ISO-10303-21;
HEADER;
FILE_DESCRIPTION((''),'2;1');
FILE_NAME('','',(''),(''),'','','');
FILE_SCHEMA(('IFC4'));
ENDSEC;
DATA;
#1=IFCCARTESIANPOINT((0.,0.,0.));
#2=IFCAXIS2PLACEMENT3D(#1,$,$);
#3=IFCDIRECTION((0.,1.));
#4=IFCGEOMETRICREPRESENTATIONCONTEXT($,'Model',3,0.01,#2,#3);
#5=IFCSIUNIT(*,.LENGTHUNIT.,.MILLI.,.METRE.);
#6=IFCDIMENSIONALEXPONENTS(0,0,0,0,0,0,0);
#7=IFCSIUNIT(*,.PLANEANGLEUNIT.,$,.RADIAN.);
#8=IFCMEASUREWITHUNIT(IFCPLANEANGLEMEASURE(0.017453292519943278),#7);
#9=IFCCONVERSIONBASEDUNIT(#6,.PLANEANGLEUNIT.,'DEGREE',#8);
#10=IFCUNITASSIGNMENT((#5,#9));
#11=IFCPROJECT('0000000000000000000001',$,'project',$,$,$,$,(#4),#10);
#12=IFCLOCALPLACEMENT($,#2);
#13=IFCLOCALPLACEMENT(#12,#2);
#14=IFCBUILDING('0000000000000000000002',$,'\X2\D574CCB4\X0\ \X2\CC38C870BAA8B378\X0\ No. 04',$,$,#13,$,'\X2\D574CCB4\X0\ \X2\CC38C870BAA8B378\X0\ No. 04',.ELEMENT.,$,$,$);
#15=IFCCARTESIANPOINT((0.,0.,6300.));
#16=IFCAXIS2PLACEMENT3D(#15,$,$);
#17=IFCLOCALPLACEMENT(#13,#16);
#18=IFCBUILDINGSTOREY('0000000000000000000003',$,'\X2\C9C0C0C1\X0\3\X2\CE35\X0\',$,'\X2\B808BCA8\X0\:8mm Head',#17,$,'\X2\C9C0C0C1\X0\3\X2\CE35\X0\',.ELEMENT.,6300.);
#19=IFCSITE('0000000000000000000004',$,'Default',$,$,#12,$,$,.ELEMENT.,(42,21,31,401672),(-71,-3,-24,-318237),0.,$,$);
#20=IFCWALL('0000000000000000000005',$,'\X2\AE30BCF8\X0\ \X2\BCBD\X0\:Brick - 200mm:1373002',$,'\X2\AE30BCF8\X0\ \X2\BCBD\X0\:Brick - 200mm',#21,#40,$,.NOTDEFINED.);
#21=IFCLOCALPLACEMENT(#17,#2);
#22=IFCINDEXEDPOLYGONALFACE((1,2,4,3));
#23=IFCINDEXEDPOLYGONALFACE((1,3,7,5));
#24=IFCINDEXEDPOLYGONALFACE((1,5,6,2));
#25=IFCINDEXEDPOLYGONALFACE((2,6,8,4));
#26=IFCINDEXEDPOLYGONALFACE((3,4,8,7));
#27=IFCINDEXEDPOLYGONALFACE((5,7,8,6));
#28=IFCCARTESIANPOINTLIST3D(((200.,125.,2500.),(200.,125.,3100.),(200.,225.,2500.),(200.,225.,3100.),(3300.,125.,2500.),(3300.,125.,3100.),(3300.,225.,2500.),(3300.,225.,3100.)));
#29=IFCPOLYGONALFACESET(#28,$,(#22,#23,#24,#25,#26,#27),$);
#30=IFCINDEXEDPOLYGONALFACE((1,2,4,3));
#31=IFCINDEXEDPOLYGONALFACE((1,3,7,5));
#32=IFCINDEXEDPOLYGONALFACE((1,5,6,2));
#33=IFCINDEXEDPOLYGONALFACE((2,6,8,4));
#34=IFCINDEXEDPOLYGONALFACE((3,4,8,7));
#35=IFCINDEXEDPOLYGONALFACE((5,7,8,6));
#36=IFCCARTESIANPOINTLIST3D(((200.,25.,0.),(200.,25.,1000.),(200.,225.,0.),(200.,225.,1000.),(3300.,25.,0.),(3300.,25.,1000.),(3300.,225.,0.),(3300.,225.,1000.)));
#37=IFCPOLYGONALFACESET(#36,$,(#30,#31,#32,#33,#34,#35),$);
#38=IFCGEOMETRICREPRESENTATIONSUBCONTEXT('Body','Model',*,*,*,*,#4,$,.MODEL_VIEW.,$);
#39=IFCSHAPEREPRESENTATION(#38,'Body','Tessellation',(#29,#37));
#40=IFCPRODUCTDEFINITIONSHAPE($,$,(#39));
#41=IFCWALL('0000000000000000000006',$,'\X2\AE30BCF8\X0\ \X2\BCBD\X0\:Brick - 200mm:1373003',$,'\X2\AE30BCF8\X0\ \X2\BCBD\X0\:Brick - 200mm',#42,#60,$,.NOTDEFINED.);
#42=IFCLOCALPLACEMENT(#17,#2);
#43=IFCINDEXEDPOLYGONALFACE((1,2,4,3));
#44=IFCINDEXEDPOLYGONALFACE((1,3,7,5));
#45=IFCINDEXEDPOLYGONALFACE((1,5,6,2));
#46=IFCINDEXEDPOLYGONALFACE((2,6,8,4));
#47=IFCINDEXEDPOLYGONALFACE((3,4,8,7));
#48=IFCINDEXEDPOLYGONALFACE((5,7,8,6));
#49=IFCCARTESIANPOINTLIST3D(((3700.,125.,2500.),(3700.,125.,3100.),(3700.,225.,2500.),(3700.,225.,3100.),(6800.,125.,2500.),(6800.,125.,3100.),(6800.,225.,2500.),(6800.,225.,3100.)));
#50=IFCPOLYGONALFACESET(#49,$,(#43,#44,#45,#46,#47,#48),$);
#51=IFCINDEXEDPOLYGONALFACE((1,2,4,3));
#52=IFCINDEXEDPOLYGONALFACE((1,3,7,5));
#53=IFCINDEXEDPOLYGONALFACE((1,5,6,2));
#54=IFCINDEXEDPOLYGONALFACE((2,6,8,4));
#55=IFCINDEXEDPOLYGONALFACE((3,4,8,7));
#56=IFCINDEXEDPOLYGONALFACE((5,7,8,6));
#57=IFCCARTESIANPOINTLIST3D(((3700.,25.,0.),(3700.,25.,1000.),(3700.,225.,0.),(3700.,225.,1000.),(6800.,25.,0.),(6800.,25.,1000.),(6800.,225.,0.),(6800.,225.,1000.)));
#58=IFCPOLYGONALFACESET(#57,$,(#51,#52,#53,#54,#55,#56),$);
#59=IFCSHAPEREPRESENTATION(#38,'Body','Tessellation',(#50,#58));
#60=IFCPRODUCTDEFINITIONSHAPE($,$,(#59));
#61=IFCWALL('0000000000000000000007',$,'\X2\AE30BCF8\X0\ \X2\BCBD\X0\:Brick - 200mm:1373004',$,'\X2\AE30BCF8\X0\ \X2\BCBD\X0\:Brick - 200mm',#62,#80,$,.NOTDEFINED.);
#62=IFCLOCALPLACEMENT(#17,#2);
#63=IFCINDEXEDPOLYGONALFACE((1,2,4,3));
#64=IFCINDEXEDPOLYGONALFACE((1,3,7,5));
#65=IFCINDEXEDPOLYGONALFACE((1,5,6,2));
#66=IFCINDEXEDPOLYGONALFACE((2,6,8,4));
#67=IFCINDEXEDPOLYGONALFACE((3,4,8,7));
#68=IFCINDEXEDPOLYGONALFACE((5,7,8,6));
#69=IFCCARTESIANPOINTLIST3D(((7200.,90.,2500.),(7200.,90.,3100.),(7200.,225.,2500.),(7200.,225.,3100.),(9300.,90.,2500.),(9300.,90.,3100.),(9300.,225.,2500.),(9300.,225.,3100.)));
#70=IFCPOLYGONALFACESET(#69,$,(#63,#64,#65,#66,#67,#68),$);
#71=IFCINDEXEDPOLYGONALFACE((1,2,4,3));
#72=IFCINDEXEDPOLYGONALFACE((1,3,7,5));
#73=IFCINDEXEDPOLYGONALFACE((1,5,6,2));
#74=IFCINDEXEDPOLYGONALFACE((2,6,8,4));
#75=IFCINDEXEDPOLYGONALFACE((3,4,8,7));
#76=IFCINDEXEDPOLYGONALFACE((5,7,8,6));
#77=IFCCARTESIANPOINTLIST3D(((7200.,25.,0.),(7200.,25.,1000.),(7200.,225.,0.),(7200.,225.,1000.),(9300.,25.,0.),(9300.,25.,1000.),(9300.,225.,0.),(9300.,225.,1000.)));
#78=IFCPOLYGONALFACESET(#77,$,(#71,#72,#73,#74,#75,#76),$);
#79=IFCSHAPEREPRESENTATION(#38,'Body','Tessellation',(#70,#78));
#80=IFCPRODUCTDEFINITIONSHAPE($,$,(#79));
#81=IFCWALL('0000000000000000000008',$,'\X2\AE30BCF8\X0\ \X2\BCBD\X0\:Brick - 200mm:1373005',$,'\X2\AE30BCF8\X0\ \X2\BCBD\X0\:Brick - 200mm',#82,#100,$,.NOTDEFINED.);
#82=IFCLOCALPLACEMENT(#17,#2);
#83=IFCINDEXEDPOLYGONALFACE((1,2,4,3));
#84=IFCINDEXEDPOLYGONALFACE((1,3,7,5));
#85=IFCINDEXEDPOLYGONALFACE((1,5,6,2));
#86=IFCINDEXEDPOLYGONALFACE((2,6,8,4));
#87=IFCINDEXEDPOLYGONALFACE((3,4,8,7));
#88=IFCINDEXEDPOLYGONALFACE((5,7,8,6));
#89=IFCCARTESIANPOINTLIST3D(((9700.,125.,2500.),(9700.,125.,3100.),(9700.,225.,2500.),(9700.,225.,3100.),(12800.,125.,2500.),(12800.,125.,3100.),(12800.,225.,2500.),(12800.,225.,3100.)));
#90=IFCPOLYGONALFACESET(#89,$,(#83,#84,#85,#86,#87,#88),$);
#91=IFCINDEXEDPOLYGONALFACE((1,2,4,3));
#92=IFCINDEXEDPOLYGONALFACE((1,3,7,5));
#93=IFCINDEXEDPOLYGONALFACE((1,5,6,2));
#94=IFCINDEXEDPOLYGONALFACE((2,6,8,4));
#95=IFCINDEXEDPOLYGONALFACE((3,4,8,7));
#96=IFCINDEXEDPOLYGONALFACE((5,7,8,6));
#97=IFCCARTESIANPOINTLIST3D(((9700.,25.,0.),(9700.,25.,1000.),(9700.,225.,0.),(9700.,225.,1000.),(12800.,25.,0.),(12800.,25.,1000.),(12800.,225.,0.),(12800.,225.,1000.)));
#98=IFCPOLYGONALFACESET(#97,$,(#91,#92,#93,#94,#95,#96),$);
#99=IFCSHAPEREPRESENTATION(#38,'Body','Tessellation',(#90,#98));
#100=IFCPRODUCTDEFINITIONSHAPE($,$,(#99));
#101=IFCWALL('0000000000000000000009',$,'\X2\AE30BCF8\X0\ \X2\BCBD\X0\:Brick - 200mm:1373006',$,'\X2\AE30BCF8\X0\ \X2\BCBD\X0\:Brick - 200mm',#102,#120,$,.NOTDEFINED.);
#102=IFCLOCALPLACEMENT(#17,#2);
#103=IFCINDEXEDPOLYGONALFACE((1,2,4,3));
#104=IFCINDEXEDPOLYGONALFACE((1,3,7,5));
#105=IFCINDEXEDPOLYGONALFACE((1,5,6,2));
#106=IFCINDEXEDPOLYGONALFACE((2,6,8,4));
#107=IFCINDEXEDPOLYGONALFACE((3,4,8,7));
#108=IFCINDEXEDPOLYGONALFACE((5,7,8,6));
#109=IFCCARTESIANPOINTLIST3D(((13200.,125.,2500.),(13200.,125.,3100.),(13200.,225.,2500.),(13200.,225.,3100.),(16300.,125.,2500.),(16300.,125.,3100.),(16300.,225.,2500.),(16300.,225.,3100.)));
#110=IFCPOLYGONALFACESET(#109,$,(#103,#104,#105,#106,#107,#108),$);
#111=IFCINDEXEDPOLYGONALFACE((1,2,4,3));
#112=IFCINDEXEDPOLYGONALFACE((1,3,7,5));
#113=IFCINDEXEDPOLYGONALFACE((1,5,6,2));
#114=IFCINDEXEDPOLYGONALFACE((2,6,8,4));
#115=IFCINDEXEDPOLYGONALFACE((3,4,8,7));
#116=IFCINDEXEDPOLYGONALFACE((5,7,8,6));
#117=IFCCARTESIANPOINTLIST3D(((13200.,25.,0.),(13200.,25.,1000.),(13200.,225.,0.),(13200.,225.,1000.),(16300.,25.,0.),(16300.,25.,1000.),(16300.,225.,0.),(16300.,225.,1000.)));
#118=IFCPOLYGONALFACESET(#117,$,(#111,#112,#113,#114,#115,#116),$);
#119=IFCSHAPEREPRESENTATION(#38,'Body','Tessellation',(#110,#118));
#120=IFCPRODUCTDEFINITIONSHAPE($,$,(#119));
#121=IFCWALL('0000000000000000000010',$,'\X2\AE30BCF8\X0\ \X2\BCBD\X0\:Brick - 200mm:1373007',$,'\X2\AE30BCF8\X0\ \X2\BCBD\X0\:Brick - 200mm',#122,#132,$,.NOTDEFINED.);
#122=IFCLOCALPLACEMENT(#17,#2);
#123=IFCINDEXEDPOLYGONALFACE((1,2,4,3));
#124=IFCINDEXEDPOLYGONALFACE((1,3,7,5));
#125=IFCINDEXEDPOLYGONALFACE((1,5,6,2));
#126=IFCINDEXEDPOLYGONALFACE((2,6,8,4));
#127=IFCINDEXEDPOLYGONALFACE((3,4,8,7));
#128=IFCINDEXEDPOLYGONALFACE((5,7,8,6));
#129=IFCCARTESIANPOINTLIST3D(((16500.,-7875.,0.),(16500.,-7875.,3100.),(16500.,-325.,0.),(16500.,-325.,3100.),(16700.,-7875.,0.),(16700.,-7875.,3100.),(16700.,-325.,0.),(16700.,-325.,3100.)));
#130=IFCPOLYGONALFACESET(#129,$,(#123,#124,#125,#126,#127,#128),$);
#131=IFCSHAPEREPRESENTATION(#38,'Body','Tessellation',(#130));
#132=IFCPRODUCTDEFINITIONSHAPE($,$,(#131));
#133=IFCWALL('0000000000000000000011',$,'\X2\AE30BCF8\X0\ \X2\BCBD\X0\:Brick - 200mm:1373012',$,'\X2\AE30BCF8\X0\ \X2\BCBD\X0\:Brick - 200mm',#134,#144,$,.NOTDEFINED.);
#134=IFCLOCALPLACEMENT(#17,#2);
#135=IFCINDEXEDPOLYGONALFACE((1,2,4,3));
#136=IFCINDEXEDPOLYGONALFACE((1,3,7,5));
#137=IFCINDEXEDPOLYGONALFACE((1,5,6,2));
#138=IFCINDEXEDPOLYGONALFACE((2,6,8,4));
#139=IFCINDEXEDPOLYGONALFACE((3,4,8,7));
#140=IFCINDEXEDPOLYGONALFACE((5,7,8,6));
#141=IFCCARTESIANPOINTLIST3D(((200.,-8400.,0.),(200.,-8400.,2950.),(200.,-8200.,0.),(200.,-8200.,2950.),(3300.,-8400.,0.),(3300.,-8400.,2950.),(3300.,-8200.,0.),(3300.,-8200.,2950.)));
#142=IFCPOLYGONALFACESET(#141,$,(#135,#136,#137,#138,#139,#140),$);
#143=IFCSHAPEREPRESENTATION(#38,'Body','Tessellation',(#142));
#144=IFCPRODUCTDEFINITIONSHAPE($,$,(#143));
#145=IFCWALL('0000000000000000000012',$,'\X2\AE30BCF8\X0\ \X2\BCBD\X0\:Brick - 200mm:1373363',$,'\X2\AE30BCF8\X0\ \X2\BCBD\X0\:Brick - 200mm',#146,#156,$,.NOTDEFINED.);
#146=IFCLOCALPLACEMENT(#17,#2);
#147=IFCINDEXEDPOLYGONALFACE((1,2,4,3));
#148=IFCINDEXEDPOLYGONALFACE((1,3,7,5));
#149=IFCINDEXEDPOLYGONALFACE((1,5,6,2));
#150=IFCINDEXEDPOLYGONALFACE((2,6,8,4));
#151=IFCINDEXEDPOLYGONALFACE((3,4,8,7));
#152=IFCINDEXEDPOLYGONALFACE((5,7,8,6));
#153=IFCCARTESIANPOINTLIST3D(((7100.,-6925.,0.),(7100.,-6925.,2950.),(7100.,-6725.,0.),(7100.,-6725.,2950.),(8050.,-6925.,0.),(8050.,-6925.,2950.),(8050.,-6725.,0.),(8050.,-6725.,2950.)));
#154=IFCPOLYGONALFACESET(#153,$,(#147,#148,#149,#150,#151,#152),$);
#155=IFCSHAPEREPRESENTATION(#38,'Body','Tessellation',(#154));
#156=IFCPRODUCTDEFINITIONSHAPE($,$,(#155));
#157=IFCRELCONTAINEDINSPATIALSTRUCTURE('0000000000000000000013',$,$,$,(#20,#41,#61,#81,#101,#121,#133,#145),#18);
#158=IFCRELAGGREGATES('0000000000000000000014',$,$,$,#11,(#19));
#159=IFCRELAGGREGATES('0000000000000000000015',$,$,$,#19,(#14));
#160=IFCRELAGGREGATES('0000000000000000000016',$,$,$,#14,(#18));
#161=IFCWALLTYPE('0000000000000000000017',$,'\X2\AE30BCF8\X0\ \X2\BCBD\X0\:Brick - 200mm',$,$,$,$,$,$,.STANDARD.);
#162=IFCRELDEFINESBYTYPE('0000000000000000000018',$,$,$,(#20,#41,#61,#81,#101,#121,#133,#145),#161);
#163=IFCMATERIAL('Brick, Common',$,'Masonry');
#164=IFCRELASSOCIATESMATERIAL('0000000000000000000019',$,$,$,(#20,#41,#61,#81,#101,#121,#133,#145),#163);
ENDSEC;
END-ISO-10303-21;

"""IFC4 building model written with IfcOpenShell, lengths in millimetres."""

from ifc_helpers import new_model, entity, si_unit, converted_unit, direction, frame, origin, place, context, subcontext, project, spatial, indexed_curve, outline, extrude, material, type_object, element, save


model = new_model("IFC4")

# Units and contexts
model_context = context("Model", 3, precision=0.01, world=origin(), true_north=direction((0.0, 1.0)))
body_context = subcontext(model_context, "Body", "Model", "MODEL_VIEW")
ifc_project = project(units=[si_unit("LENGTHUNIT", "METRE", prefix="MILLI"), converted_unit("PLANEANGLEUNIT", "DEGREE", entity("IfcPlaneAngleMeasure", 0.017453292519943278), si_unit("PLANEANGLEUNIT", "RADIAN"), dimensions=[0, 0, 0, 0, 0, 0, 0])], contexts=[model_context])

# Site, building, storey
site_placement = place(None, origin())
site = spatial("IfcSite", under=ifc_project, at=site_placement, Name="Default", CompositionType="ELEMENT", RefLatitude=(42, 21, 31, 401672), RefLongitude=(-71, -3, -24, -318237), RefElevation=0.0)
building_placement = place(site_placement, origin())
building = spatial("IfcBuilding", under=site, at=building_placement, Name="해체 참조모델 No. 04", LongName="해체 참조모델 No. 04", CompositionType="ELEMENT")
storey_placement = place(building_placement, frame((0.0, 0.0, 6300.0)))
storey = spatial("IfcBuildingStorey", under=building, at=storey_placement, Name="지상3층", ObjectType="레벨:8mm Head", LongName="지상3층", CompositionType="ELEMENT", Elevation=6300.0)

# Shared definitions
ifc_material_1 = material(Name="Brick, Common", Category="Masonry")
wall_type = type_object("IfcWallType", Name="기본 벽:Brick - 200mm", PredefinedType="STANDARD")

# Walls, openings
wall_1_placement = place(storey_placement, frame((200.0, 125.0, 0.0)))
wall_1 = element("IfcWall", 1, at=wall_1_placement, inside=storey, type_object=wall_type, material=ifc_material_1, Name="기본 벽:Brick - 200mm:1373002", ObjectType="기본 벽:Brick - 200mm", PredefinedType="NOTDEFINED", context=body_context, shape_type="SweptSolid", body=[
    extrude(outline(indexed_curve([(-50.0, -1550.0), (50.0, -1550.0), (50.0, 1550.0), (-50.0, 1550.0), (-50.0, -1550.0)], self_intersect=False)), frame((1550.0, 50.0, 2500.0), z_axis=(0.0, 0.0, 1.0), x_axis=(0.0, -1.0, 0.0)), (0.0, 0.0, 1.0), 600.0),
    extrude(outline(indexed_curve([(-100.0, -1550.0), (0.0, -1550.0), (100.0, -1550.0), (100.0, 1550.0), (0.0, 1550.0), (-100.0, 1550.0), (-100.0, -1550.0)], self_intersect=False)), frame((1550.0, 0.0, 0.0), z_axis=(0.0, 0.0, 1.0), x_axis=(0.0, 1.0, 0.0)), (0.0, 0.0, 1.0), 1000.0),
])
opening_1_placement = place(wall_1_placement, origin())
element("IfcOpeningElement", 2, at=opening_1_placement, cuts=wall_1, PredefinedType="OPENING", context=body_context, shape_type="SweptSolid", body=[
    extrude(outline(indexed_curve([(-750.0, -1550.0), (750.0, -1550.0), (750.0, 1550.0), (-750.0, 1550.0), (-750.0, -1550.0)], self_intersect=False)), frame((1550.0, -252.4, 1750.0), z_axis=(0.0, 1.0, 0.0), x_axis=(0.0, 0.0, 1.0)), (0.0, 0.0, 1.0), 504.8),
])
wall_2_placement = place(storey_placement, frame((3700.0, 125.0, 0.0)))
wall_2 = element("IfcWall", 3, at=wall_2_placement, inside=storey, type_object=wall_type, material=ifc_material_1, Name="기본 벽:Brick - 200mm:1373003", ObjectType="기본 벽:Brick - 200mm", PredefinedType="NOTDEFINED", context=body_context, shape_type="SweptSolid", body=[
    extrude(outline(indexed_curve([(-50.0, -1550.0), (50.0, -1550.0), (50.0, 1550.0), (-50.0, 1550.0), (-50.0, -1550.0)], self_intersect=False)), frame((1550.0, 50.0, 2500.0), z_axis=(0.0, 0.0, 1.0), x_axis=(0.0, -1.0, 0.0)), (0.0, 0.0, 1.0), 600.0),
    extrude(outline(indexed_curve([(-100.0, -1550.0), (0.0, -1550.0), (100.0, -1550.0), (100.0, 1550.0), (0.0, 1550.0), (-100.0, 1550.0), (-100.0, -1550.0)], self_intersect=False)), frame((1550.0, 0.0, 0.0), z_axis=(0.0, 0.0, 1.0), x_axis=(0.0, 1.0, 0.0)), (0.0, 0.0, 1.0), 1000.0),
])
opening_2_placement = place(wall_2_placement, origin())
element("IfcOpeningElement", 4, at=opening_2_placement, cuts=wall_2, PredefinedType="OPENING", context=body_context, shape_type="SweptSolid", body=[
    extrude(outline(indexed_curve([(-750.0, -1550.0), (750.0, -1550.0), (750.0, 1550.0), (-750.0, 1550.0), (-750.0, -1550.0)], self_intersect=False)), frame((1550.0, -252.4, 1750.0), z_axis=(0.0, 1.0, 0.0), x_axis=(0.0, 0.0, 1.0)), (0.0, 0.0, 1.0), 504.8),
])
wall_3_placement = place(storey_placement, frame((7200.0, 125.0, 0.0)))
wall_3 = element("IfcWall", 5, at=wall_3_placement, inside=storey, type_object=wall_type, material=ifc_material_1, Name="기본 벽:Brick - 200mm:1373004", ObjectType="기본 벽:Brick - 200mm", PredefinedType="NOTDEFINED", context=body_context, shape_type="SweptSolid", body=[
    extrude(outline(indexed_curve([(-67.5, -1050.0), (67.5, -1050.0), (67.5, 1050.0), (-67.5, 1050.0), (-67.5, -1050.0)], self_intersect=False)), frame((1050.0, 32.5, 2500.0), z_axis=(0.0, 0.0, 1.0), x_axis=(0.0, -1.0, 0.0)), (0.0, 0.0, 1.0), 600.0),
    extrude(outline(indexed_curve([(-88.3, -1050.0), (-23.3, -1050.0), (111.7, -1050.0), (111.7, 1050.0), (-23.3, 1050.0), (-88.3, 1050.0), (-88.3, -1050.0)], self_intersect=False)), frame((1050.0, -11.7, 0.0), z_axis=(0.0, 0.0, 1.0), x_axis=(0.0, 1.0, 0.0)), (0.0, 0.0, 1.0), 1000.0),
])
opening_3_placement = place(wall_3_placement, origin())
element("IfcOpeningElement", 6, at=opening_3_placement, cuts=wall_3, PredefinedType="OPENING", context=body_context, shape_type="SweptSolid", body=[
    extrude(outline(indexed_curve([(-750.0, -1050.0), (750.0, -1050.0), (750.0, 1050.0), (-750.0, 1050.0), (-750.0, -1050.0)], self_intersect=False)), frame((1050.0, -252.4, 1750.0), z_axis=(0.0, 1.0, 0.0), x_axis=(0.0, 0.0, 1.0)), (0.0, 0.0, 1.0), 504.8),
])
wall_4_placement = place(storey_placement, frame((9700.0, 125.0, 0.0)))
wall_4 = element("IfcWall", 7, at=wall_4_placement, inside=storey, type_object=wall_type, material=ifc_material_1, Name="기본 벽:Brick - 200mm:1373005", ObjectType="기본 벽:Brick - 200mm", PredefinedType="NOTDEFINED", context=body_context, shape_type="SweptSolid", body=[
    extrude(outline(indexed_curve([(-50.0, -1550.0), (50.0, -1550.0), (50.0, 1550.0), (-50.0, 1550.0), (-50.0, -1550.0)], self_intersect=False)), frame((1550.0, 50.0, 2500.0), z_axis=(0.0, 0.0, 1.0), x_axis=(0.0, -1.0, 0.0)), (0.0, 0.0, 1.0), 600.0),
    extrude(outline(indexed_curve([(-100.0, -1550.0), (0.0, -1550.0), (100.0, -1550.0), (100.0, 1550.0), (0.0, 1550.0), (-100.0, 1550.0), (-100.0, -1550.0)], self_intersect=False)), frame((1550.0, 0.0, 0.0), z_axis=(0.0, 0.0, 1.0), x_axis=(0.0, 1.0, 0.0)), (0.0, 0.0, 1.0), 1000.0),
])
opening_4_placement = place(wall_4_placement, origin())
element("IfcOpeningElement", 8, at=opening_4_placement, cuts=wall_4, PredefinedType="OPENING", context=body_context, shape_type="SweptSolid", body=[
    extrude(outline(indexed_curve([(-750.0, -1550.0), (750.0, -1550.0), (750.0, 1550.0), (-750.0, 1550.0), (-750.0, -1550.0)], self_intersect=False)), frame((1550.0, -252.4, 1750.0), z_axis=(0.0, 1.0, 0.0), x_axis=(0.0, 0.0, 1.0)), (0.0, 0.0, 1.0), 504.8),
])
wall_5_placement = place(storey_placement, frame((13200.0, 125.0, 0.0)))
wall_5 = element("IfcWall", 9, at=wall_5_placement, inside=storey, type_object=wall_type, material=ifc_material_1, Name="기본 벽:Brick - 200mm:1373006", ObjectType="기본 벽:Brick - 200mm", PredefinedType="NOTDEFINED", context=body_context, shape_type="SweptSolid", body=[
    extrude(outline(indexed_curve([(-50.0, -1550.0), (50.0, -1550.0), (50.0, 1550.0), (-50.0, 1550.0), (-50.0, -1550.0)], self_intersect=False)), frame((1550.0, 50.0, 2500.0), z_axis=(0.0, 0.0, 1.0), x_axis=(0.0, -1.0, 0.0)), (0.0, 0.0, 1.0), 600.0),
    extrude(outline(indexed_curve([(-100.0, -1550.0), (0.0, -1550.0), (100.0, -1550.0), (100.0, 1550.0), (0.0, 1550.0), (-100.0, 1550.0), (-100.0, -1550.0)], self_intersect=False)), frame((1550.0, 0.0, 0.0), z_axis=(0.0, 0.0, 1.0), x_axis=(0.0, 1.0, 0.0)), (0.0, 0.0, 1.0), 1000.0),
])
opening_5_placement = place(wall_5_placement, origin())
element("IfcOpeningElement", 10, at=opening_5_placement, cuts=wall_5, PredefinedType="OPENING", context=body_context, shape_type="SweptSolid", body=[
    extrude(outline(indexed_curve([(-750.0, -1550.0), (750.0, -1550.0), (750.0, 1550.0), (-750.0, 1550.0), (-750.0, -1550.0)], self_intersect=False)), frame((1550.0, -252.4, 1750.0), z_axis=(0.0, 1.0, 0.0), x_axis=(0.0, 0.0, 1.0)), (0.0, 0.0, 1.0), 504.8),
])

# Walls
wall_6_placement = place(storey_placement, frame((16600.0, -325.0, 0.0), z_axis=(0.0, 0.0, 1.0), x_axis=(0.0, -1.0, 0.0)))
element("IfcWall", 11, at=wall_6_placement, inside=storey, type_object=wall_type, material=ifc_material_1, Name="기본 벽:Brick - 200mm:1373007", ObjectType="기본 벽:Brick - 200mm", PredefinedType="NOTDEFINED", context=body_context, shape_type="SweptSolid", body=[
    extrude(outline(indexed_curve([(7550.0, 100.0), (0.0, 100.0), (0.0, -100.0), (7550.0, -100.0), (7550.0, 100.0)], self_intersect=False)), origin(), (0.0, 0.0, 1.0), 3100.0),
])
wall_7_placement = place(storey_placement, frame((3300.0, -8300.0, 0.0), z_axis=(0.0, 0.0, 1.0), x_axis=(-1.0, 0.0, 0.0)))
element("IfcWall", 12, at=wall_7_placement, inside=storey, type_object=wall_type, material=ifc_material_1, Name="기본 벽:Brick - 200mm:1373012", ObjectType="기본 벽:Brick - 200mm", PredefinedType="NOTDEFINED", context=body_context, shape_type="SweptSolid", body=[
    extrude(outline(indexed_curve([(3100.0, 100.0), (0.0, 100.0), (0.0, -100.0), (3100.0, -100.0), (3100.0, 100.0)], self_intersect=False)), origin(), (0.0, 0.0, 1.0), 2950.0),
])
wall_8_placement = place(storey_placement, frame((8050.0, -6825.0, 0.0), z_axis=(0.0, 0.0, 1.0), x_axis=(-1.0, 0.0, 0.0)))
element("IfcWall", 13, at=wall_8_placement, inside=storey, type_object=wall_type, material=ifc_material_1, Name="기본 벽:Brick - 200mm:1373363", ObjectType="기본 벽:Brick - 200mm", PredefinedType="NOTDEFINED", context=body_context, shape_type="SweptSolid", body=[
    extrude(outline(indexed_curve([(950.0, 100.0), (0.0, 100.0), (0.0, -100.0), (950.0, -100.0), (950.0, 100.0)], self_intersect=False)), origin(), (0.0, 0.0, 1.0), 2950.0),
])

save(model, "model.ifc")
